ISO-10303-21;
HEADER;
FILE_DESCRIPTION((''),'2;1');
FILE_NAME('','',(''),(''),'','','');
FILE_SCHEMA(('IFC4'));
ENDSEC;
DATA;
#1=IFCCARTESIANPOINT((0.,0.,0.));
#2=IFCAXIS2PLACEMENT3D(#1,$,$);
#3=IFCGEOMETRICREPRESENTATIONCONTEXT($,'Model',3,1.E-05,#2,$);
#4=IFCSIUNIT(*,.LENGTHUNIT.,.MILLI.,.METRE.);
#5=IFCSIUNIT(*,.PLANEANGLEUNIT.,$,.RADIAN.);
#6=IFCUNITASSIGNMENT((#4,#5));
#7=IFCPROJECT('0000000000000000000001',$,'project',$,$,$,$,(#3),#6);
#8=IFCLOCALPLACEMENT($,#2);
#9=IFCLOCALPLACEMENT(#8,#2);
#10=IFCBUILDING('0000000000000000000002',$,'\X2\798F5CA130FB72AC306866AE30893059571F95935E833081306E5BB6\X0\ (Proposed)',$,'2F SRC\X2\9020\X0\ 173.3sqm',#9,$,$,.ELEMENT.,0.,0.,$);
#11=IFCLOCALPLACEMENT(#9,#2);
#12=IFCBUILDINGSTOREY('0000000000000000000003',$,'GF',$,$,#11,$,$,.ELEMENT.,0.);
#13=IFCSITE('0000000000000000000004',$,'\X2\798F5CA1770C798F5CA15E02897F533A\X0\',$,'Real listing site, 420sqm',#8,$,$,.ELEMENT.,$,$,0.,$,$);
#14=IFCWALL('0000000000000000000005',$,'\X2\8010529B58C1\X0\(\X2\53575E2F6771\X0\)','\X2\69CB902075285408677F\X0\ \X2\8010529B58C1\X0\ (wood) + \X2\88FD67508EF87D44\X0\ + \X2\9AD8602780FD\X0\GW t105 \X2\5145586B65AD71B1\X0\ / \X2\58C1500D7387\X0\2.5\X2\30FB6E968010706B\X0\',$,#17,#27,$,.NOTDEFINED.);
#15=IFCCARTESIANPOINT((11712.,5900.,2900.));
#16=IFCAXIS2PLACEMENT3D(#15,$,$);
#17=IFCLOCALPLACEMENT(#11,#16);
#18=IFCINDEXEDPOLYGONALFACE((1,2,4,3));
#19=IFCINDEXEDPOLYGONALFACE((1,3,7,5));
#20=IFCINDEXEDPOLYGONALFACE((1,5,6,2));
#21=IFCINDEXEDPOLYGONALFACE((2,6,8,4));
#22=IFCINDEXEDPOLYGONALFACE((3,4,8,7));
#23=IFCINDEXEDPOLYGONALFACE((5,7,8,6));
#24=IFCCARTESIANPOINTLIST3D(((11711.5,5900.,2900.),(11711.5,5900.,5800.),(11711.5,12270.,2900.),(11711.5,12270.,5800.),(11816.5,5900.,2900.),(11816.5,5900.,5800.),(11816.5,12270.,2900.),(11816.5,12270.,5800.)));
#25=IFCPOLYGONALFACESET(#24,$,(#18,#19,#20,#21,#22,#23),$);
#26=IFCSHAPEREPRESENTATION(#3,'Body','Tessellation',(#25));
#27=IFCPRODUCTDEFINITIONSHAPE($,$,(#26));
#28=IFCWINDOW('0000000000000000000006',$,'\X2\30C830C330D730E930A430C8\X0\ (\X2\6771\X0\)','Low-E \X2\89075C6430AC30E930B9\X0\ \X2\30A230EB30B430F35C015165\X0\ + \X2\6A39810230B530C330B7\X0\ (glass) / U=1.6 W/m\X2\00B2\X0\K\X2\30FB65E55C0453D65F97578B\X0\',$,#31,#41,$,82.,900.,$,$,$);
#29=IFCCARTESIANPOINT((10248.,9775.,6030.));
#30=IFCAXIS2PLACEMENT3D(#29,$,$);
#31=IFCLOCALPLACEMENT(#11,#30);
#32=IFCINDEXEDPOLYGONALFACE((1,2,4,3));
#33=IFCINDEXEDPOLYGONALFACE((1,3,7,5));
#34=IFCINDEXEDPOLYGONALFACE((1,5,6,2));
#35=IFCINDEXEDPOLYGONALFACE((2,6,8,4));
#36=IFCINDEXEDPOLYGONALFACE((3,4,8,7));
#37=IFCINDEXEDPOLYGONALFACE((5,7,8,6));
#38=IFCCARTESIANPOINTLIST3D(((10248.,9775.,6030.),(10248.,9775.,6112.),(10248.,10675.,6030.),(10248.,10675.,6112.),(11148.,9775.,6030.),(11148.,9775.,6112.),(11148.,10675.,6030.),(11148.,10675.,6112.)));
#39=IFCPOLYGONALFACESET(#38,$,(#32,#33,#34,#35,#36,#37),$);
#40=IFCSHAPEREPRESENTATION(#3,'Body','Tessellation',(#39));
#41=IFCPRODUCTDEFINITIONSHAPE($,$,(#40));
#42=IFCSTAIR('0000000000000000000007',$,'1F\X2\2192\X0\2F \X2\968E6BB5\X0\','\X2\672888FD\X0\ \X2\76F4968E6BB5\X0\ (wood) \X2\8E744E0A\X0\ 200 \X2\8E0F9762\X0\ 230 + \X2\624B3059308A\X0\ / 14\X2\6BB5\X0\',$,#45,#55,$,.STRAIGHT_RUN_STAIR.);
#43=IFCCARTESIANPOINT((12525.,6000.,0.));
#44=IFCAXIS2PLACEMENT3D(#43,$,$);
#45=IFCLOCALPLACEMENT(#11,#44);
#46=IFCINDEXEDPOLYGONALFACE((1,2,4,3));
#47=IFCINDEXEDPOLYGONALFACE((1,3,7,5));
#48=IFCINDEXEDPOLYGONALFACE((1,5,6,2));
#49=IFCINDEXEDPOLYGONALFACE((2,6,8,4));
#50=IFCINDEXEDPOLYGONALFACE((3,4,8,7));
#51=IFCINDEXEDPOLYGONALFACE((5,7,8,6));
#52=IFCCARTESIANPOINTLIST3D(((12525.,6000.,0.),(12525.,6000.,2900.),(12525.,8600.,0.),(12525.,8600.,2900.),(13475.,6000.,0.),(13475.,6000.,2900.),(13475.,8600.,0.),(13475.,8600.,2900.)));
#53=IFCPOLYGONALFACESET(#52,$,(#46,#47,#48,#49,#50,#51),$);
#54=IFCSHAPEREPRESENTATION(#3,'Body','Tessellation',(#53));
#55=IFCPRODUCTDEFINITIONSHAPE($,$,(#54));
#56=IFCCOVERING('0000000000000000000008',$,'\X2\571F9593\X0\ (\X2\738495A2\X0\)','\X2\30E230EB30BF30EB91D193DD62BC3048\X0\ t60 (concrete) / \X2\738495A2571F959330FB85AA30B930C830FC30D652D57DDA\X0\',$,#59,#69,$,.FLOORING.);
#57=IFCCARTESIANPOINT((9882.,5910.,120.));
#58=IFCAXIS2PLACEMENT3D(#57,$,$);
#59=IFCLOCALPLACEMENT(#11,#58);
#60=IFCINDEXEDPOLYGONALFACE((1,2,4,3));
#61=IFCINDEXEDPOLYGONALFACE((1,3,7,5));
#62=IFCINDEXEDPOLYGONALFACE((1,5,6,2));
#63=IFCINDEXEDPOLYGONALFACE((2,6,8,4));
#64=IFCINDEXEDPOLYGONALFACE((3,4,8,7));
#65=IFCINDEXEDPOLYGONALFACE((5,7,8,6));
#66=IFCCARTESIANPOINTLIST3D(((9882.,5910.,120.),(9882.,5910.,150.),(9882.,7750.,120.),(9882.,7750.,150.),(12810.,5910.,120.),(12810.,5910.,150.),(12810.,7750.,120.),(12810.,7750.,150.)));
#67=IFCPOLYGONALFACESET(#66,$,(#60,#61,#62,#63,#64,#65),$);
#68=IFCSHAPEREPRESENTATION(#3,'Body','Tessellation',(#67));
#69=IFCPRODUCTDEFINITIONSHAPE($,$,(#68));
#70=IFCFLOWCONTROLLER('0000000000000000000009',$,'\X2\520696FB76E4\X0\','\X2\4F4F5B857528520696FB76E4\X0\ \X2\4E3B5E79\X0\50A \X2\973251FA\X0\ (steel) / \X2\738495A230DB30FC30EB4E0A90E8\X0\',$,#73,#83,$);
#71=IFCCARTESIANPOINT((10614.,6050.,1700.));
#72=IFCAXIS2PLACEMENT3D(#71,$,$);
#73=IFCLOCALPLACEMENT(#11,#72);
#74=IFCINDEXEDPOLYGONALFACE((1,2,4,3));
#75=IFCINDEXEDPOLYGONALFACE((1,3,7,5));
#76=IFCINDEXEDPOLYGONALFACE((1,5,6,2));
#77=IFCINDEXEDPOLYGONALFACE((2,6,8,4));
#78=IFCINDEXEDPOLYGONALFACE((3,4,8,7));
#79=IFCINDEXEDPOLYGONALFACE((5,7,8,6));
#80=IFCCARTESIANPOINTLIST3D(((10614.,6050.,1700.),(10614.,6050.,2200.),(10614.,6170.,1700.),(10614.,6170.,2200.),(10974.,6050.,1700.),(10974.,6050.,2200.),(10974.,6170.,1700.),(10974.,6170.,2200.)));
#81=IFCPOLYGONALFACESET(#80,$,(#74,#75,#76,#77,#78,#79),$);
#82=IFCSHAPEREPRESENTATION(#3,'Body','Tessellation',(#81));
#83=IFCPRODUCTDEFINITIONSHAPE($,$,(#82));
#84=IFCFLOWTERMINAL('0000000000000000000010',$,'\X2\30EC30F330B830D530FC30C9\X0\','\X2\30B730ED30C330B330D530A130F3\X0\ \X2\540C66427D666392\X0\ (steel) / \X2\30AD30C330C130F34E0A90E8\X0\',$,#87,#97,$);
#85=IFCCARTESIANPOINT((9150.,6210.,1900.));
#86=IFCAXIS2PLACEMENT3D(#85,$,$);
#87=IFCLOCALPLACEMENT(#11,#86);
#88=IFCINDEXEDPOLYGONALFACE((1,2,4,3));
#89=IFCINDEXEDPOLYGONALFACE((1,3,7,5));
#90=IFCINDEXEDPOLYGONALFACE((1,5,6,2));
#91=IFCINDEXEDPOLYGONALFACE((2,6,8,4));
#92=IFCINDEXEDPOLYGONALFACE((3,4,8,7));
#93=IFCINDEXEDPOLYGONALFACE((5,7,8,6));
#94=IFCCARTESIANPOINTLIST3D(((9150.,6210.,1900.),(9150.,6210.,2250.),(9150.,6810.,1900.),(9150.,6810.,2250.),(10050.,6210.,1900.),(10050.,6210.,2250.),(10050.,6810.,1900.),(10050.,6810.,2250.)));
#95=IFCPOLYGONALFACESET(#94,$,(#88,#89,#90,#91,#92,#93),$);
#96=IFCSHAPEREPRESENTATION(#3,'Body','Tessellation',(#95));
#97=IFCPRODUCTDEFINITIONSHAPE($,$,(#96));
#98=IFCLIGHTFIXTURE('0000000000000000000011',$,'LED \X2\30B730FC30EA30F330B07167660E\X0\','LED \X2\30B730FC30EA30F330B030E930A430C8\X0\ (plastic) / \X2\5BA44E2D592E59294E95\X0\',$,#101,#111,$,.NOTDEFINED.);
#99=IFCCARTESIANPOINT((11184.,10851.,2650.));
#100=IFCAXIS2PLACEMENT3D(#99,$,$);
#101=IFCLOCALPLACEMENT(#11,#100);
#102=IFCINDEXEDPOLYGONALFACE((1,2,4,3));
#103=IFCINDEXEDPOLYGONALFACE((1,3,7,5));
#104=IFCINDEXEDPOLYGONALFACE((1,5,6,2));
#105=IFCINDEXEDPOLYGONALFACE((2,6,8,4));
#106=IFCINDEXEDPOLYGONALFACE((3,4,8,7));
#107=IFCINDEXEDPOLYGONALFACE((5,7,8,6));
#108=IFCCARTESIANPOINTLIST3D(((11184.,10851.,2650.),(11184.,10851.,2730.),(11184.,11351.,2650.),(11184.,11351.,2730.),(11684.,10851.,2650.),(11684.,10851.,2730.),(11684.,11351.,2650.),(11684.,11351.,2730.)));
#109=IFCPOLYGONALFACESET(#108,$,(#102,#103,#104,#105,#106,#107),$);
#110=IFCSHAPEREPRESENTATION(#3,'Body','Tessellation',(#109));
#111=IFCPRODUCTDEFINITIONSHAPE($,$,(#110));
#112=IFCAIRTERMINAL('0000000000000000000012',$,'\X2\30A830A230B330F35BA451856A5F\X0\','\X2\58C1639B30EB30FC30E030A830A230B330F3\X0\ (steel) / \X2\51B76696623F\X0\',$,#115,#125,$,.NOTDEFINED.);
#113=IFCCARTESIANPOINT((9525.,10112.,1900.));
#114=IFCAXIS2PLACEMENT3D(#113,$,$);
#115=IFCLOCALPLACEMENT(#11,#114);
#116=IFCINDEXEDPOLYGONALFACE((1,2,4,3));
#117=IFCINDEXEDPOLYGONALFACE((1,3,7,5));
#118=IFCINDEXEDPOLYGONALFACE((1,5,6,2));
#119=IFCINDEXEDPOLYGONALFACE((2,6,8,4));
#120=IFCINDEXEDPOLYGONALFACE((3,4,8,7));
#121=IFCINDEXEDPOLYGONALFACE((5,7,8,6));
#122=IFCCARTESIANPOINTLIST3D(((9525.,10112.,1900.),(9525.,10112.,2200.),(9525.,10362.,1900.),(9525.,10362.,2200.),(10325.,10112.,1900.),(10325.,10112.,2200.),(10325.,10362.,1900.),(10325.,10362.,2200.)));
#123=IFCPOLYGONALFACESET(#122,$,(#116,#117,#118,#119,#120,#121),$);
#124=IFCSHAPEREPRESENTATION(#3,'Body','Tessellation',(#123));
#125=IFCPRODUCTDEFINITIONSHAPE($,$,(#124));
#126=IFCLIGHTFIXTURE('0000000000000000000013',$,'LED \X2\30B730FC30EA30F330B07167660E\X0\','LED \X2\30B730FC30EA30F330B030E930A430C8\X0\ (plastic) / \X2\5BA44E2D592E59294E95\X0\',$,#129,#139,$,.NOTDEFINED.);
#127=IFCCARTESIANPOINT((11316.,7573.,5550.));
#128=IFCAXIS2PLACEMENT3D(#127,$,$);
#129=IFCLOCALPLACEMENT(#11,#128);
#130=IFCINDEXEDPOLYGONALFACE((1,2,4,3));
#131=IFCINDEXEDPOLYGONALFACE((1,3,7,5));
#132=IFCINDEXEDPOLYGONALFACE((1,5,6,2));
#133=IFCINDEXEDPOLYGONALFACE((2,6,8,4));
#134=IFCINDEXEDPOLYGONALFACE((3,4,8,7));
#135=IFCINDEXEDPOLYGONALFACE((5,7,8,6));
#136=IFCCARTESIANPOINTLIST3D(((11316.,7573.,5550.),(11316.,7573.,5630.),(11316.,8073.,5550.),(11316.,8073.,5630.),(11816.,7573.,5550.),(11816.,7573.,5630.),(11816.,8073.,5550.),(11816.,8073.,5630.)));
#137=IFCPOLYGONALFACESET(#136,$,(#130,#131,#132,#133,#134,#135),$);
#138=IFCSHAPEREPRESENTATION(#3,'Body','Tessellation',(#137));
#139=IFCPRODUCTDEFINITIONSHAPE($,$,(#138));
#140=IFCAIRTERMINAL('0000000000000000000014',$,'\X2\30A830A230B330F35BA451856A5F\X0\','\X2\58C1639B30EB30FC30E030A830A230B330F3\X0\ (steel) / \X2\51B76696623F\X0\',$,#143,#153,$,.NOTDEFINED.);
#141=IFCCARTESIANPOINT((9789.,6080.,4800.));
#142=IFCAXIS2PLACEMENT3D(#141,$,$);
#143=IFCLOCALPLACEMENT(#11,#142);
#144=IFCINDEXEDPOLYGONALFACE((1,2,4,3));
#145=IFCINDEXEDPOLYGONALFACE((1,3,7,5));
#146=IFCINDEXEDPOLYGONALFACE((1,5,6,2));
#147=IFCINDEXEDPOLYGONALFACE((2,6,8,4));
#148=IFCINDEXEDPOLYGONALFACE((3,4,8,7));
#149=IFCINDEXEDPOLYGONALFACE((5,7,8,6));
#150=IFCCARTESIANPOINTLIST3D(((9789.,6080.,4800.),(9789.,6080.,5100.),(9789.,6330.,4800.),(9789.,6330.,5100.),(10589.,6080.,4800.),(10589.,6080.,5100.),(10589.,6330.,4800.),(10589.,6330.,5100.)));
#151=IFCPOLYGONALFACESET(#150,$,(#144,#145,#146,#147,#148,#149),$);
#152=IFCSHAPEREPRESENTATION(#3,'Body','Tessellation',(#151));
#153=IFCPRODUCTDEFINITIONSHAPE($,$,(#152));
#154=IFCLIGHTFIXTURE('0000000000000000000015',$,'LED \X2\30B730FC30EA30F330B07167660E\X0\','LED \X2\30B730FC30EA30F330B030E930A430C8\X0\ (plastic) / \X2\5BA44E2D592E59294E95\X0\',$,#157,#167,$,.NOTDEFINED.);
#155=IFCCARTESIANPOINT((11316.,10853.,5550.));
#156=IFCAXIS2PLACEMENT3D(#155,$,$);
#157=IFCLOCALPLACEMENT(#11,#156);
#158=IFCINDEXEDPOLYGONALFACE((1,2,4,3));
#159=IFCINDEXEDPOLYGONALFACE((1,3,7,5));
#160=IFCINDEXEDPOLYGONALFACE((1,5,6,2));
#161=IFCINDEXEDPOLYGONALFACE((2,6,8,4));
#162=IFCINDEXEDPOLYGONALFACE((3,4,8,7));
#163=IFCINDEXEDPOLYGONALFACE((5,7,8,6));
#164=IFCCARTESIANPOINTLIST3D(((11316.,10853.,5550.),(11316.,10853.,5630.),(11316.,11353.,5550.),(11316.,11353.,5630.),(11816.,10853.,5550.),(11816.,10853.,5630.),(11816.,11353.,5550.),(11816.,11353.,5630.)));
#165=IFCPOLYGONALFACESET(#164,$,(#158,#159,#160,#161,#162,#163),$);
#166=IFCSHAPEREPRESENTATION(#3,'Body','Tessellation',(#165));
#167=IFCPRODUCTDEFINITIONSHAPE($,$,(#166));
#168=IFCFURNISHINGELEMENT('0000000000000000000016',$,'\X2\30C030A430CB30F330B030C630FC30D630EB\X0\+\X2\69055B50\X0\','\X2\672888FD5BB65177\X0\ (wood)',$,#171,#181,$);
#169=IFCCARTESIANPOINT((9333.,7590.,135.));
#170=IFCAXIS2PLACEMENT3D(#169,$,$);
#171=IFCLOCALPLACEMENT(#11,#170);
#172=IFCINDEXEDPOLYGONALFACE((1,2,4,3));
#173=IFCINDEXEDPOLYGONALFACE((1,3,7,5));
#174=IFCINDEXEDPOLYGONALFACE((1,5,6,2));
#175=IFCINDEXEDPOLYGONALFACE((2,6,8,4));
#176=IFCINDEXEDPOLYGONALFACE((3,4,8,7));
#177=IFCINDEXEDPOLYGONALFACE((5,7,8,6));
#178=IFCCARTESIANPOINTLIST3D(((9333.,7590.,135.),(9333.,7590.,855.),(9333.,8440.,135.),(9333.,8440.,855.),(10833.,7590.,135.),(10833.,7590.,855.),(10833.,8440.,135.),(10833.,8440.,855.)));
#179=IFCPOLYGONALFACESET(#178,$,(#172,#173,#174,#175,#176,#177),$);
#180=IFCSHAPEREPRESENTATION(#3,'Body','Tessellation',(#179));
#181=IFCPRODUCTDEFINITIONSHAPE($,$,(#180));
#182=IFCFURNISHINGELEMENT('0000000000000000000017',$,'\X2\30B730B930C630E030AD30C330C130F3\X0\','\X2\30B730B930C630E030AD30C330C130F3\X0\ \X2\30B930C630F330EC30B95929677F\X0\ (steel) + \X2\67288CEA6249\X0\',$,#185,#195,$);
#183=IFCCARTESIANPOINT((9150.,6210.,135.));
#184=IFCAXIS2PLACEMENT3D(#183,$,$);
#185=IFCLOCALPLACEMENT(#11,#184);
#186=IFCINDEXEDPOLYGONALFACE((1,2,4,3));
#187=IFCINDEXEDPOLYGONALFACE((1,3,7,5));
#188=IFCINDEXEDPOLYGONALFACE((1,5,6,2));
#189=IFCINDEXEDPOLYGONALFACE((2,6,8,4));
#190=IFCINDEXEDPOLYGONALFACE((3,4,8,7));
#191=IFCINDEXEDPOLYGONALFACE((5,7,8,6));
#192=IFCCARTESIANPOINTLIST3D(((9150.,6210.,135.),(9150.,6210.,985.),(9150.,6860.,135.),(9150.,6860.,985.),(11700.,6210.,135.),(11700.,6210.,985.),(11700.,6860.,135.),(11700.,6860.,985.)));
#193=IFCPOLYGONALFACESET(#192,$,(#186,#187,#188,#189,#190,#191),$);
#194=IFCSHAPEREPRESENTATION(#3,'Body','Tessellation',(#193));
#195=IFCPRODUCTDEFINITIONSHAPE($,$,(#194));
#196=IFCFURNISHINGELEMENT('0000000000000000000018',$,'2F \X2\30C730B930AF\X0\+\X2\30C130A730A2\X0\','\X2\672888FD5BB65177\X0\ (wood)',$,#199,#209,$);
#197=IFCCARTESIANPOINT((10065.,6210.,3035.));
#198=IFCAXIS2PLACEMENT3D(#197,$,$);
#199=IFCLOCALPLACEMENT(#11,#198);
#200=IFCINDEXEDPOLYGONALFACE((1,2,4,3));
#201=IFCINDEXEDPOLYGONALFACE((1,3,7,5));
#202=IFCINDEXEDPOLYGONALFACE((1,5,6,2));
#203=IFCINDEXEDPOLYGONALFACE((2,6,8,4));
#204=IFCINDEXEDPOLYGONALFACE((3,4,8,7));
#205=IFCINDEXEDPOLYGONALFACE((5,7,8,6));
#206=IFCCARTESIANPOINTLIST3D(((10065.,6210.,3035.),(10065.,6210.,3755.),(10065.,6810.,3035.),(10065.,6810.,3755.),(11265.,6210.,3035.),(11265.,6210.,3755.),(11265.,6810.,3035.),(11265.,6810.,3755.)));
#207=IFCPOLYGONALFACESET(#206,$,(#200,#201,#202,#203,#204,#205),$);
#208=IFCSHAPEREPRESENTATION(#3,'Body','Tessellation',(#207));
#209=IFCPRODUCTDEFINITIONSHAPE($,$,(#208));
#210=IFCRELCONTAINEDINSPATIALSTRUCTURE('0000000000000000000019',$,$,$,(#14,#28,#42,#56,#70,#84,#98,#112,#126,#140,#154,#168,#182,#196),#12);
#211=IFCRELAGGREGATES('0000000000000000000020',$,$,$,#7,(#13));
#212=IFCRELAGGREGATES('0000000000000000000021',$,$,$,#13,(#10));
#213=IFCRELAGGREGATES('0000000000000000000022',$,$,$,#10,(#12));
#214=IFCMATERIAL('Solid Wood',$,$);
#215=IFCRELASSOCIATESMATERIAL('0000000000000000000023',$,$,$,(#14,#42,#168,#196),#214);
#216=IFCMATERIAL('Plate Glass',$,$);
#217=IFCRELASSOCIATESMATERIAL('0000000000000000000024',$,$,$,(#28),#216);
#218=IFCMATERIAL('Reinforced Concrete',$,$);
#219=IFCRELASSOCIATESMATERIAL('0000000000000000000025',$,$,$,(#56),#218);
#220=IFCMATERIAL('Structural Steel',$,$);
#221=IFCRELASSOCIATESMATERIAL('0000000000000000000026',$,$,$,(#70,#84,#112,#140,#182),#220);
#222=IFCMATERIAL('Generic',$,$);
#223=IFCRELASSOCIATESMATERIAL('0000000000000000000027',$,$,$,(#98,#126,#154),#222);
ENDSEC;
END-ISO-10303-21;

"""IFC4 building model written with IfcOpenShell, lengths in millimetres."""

from ifc_helpers import new_model, si_unit, frame, frame_2d, origin, place, context, project, spatial, rectangle, extrude, material, element, save


model = new_model("IFC4")

# Units and contexts
model_context = context("Model", 3, precision=1e-05, world=origin())
ifc_project = project(units=[si_unit("LENGTHUNIT", "METRE", prefix="MILLI"), si_unit("PLANEANGLEUNIT", "RADIAN")], contexts=[model_context])

# Site, building, storey
site_placement = place(None, origin())
site = spatial("IfcSite", under=ifc_project, at=site_placement, Name="福岡県福岡市西区", ObjectType="Real listing site, 420sqm", CompositionType="ELEMENT", RefElevation=0.0)
building_placement = place(site_placement, origin())
building = spatial("IfcBuilding", under=site, at=building_placement, Name="福岡・犬と暮らす土間広めの家 (Proposed)", ObjectType="2F SRC造 173.3sqm", CompositionType="ELEMENT", ElevationOfRefHeight=0.0, ElevationOfTerrain=0.0)
storey_placement = place(building_placement, origin())
storey = spatial("IfcBuildingStorey", under=building, at=storey_placement, Name="GF", CompositionType="ELEMENT", Elevation=0.0)

# Shared definitions
ifc_material_1 = material(Name="Solid Wood")

# Wall
wall_1_placement = place(storey_placement, frame((11712.0, 5900.0, 2900.0)))
element("IfcWall", 1, at=wall_1_placement, inside=storey, material=ifc_material_1, Name="耐力壁(南帯東)", Description="構造用合板 耐力壁 (wood) + 製材軸組 + 高性能GW t105 充填断熱 / 壁倍率2.5・準耐火", PredefinedType="NOTDEFINED", context=model_context, shape_type="SweptSolid", body=[
    extrude(rectangle(XDim=105.0, YDim=6370.0, at=frame_2d((52.0, 3185.0))), frame((11712.0, 5900.0, 2900.0)), (0.0, 0.0, 1.0), 2900.0),
])

# Window
ifc_material_2 = material(Name="Plate Glass")
window_placement = place(storey_placement, frame((10248.0, 9775.0, 6030.0)))
element("IfcWindow", 2, at=window_placement, inside=storey, material=ifc_material_2, Name="トップライト (東)", Description="Low-E 複層ガラス アルゴン封入 + 樹脂サッシ (glass) / U=1.6 W/m²K・日射取得型", OverallHeight=82.0, OverallWidth=900.0, context=model_context, shape_type="SweptSolid", body=[
    extrude(rectangle(XDim=900.0, YDim=900.0, at=frame_2d((450.0, 450.0))), frame((10248.0, 9775.0, 6030.0)), (0.0, 0.0, 1.0), 82.0),
])

# Stair
stair_placement = place(storey_placement, frame((12525.0, 6000.0, 0.0)))
element("IfcStair", 3, at=stair_placement, inside=storey, material=ifc_material_1, Name="1F→2F 階段", Description="木製 直階段 (wood) 蹴上 200 踏面 230 + 手すり / 14段", PredefinedType="STRAIGHT_RUN_STAIR", context=model_context, shape_type="SweptSolid", body=[
    extrude(rectangle(XDim=950.0, YDim=2600.0, at=frame_2d((475.0, 1300.0))), frame((12525.0, 6000.0, 0.0)), (0.0, 0.0, 1.0), 2900.0),
])

# Covering
ifc_material_3 = material(Name="Reinforced Concrete")
covering_placement = place(storey_placement, frame((9882.0, 5910.0, 120.0)))
element("IfcCovering", 4, at=covering_placement, inside=storey, material=ifc_material_3, Name="土間 (玄関)", Description="モルタル金鏝押え t60 (concrete) / 玄関土間・薪ストーブ動線", PredefinedType="FLOORING", context=model_context, shape_type="SweptSolid", body=[
    extrude(rectangle(XDim=2928.0, YDim=1840.0, at=frame_2d((1464.0, 920.0))), frame((9882.0, 5910.0, 120.0)), (0.0, 0.0, 1.0), 30.0),
])

# Flow controller
ifc_material_4 = material(Name="Structural Steel")
flow_controller_placement = place(storey_placement, frame((10614.0, 6050.0, 1700.0)))
element("IfcFlowController", 5, at=flow_controller_placement, inside=storey, material=ifc_material_4, Name="分電盤", Description="住宅用分電盤 主幹50A 露出 (steel) / 玄関ホール上部", context=model_context, shape_type="SweptSolid", body=[
    extrude(rectangle(XDim=360.0, YDim=120.0, at=frame_2d((180.0, 60.0))), frame((10614.0, 6050.0, 1700.0)), (0.0, 0.0, 1.0), 500.0),
])

# Flow terminal
flow_terminal_placement = place(storey_placement, frame((9150.0, 6210.0, 1900.0)))
element("IfcFlowTerminal", 6, at=flow_terminal_placement, inside=storey, material=ifc_material_4, Name="レンジフード", Description="シロッコファン 同時給排 (steel) / キッチン上部", context=model_context, shape_type="SweptSolid", body=[
    extrude(rectangle(XDim=900.0, YDim=600.0, at=frame_2d((450.0, 300.0))), frame((9150.0, 6210.0, 1900.0)), (0.0, 0.0, 1.0), 350.0),
])

# Light fixture
ifc_material_5 = material(Name="Generic")
light_fixture_1_placement = place(storey_placement, frame((11184.0, 10851.0, 2650.0)))
element("IfcLightFixture", 7, at=light_fixture_1_placement, inside=storey, material=ifc_material_5, Name="LED シーリング照明", Description="LED シーリングライト (plastic) / 室中央天井", PredefinedType="NOTDEFINED", context=model_context, shape_type="SweptSolid", body=[
    extrude(rectangle(XDim=500.0, YDim=500.0, at=frame_2d((250.0, 250.0))), frame((11184.0, 10851.0, 2650.0)), (0.0, 0.0, 1.0), 80.0),
])

# Air terminal
air_terminal_1_placement = place(storey_placement, frame((9525.0, 10112.0, 1900.0)))
element("IfcAirTerminal", 8, at=air_terminal_1_placement, inside=storey, material=ifc_material_4, Name="エアコン室内機", Description="壁掛ルームエアコン (steel) / 冷暖房", PredefinedType="NOTDEFINED", context=model_context, shape_type="SweptSolid", body=[
    extrude(rectangle(XDim=800.0, YDim=250.0, at=frame_2d((400.0, 125.0))), frame((9525.0, 10112.0, 1900.0)), (0.0, 0.0, 1.0), 300.0),
])

# Light fixture
light_fixture_2_placement = place(storey_placement, frame((11316.0, 7573.0, 5550.0)))
element("IfcLightFixture", 9, at=light_fixture_2_placement, inside=storey, material=ifc_material_5, Name="LED シーリング照明", Description="LED シーリングライト (plastic) / 室中央天井", PredefinedType="NOTDEFINED", context=model_context, shape_type="SweptSolid", body=[
    extrude(rectangle(XDim=500.0, YDim=500.0, at=frame_2d((250.0, 250.0))), frame((11316.0, 7573.0, 5550.0)), (0.0, 0.0, 1.0), 80.0),
])

# Air terminal
air_terminal_2_placement = place(storey_placement, frame((9789.0, 6080.0, 4800.0)))
element("IfcAirTerminal", 10, at=air_terminal_2_placement, inside=storey, material=ifc_material_4, Name="エアコン室内機", Description="壁掛ルームエアコン (steel) / 冷暖房", PredefinedType="NOTDEFINED", context=model_context, shape_type="SweptSolid", body=[
    extrude(rectangle(XDim=800.0, YDim=250.0, at=frame_2d((400.0, 125.0))), frame((9789.0, 6080.0, 4800.0)), (0.0, 0.0, 1.0), 300.0),
])

# Light fixture
light_fixture_3_placement = place(storey_placement, frame((11316.0, 10853.0, 5550.0)))
element("IfcLightFixture", 11, at=light_fixture_3_placement, inside=storey, material=ifc_material_5, Name="LED シーリング照明", Description="LED シーリングライト (plastic) / 室中央天井", PredefinedType="NOTDEFINED", context=model_context, shape_type="SweptSolid", body=[
    extrude(rectangle(XDim=500.0, YDim=500.0, at=frame_2d((250.0, 250.0))), frame((11316.0, 10853.0, 5550.0)), (0.0, 0.0, 1.0), 80.0),
])

# Furnishing elements
furnishing_1_placement = place(storey_placement, frame((9333.0, 7590.0, 135.0)))
element("IfcFurnishingElement", 12, at=furnishing_1_placement, inside=storey, material=ifc_material_1, Name="ダイニングテーブル+椅子", Description="木製家具 (wood)", context=model_context, shape_type="SweptSolid", body=[
    extrude(rectangle(XDim=1500.0, YDim=850.0, at=frame_2d((750.0, 425.0))), frame((9333.0, 7590.0, 135.0)), (0.0, 0.0, 1.0), 720.0),
])
furnishing_2_placement = place(storey_placement, frame((9150.0, 6210.0, 135.0)))
element("IfcFurnishingElement", 13, at=furnishing_2_placement, inside=storey, material=ifc_material_4, Name="システムキッチン", Description="システムキッチン ステンレス天板 (steel) + 木質扉", context=model_context, shape_type="SweptSolid", body=[
    extrude(rectangle(XDim=2550.0, YDim=650.0, at=frame_2d((1275.0, 325.0))), frame((9150.0, 6210.0, 135.0)), (0.0, 0.0, 1.0), 850.0),
])
furnishing_3_placement = place(storey_placement, frame((10065.0, 6210.0, 3035.0)))
element("IfcFurnishingElement", 14, at=furnishing_3_placement, inside=storey, material=ifc_material_1, Name="2F デスク+チェア", Description="木製家具 (wood)", context=model_context, shape_type="SweptSolid", body=[
    extrude(rectangle(XDim=1200.0, YDim=600.0, at=frame_2d((600.0, 300.0))), frame((10065.0, 6210.0, 3035.0)), (0.0, 0.0, 1.0), 720.0),
])

save(model, "model.ifc")
